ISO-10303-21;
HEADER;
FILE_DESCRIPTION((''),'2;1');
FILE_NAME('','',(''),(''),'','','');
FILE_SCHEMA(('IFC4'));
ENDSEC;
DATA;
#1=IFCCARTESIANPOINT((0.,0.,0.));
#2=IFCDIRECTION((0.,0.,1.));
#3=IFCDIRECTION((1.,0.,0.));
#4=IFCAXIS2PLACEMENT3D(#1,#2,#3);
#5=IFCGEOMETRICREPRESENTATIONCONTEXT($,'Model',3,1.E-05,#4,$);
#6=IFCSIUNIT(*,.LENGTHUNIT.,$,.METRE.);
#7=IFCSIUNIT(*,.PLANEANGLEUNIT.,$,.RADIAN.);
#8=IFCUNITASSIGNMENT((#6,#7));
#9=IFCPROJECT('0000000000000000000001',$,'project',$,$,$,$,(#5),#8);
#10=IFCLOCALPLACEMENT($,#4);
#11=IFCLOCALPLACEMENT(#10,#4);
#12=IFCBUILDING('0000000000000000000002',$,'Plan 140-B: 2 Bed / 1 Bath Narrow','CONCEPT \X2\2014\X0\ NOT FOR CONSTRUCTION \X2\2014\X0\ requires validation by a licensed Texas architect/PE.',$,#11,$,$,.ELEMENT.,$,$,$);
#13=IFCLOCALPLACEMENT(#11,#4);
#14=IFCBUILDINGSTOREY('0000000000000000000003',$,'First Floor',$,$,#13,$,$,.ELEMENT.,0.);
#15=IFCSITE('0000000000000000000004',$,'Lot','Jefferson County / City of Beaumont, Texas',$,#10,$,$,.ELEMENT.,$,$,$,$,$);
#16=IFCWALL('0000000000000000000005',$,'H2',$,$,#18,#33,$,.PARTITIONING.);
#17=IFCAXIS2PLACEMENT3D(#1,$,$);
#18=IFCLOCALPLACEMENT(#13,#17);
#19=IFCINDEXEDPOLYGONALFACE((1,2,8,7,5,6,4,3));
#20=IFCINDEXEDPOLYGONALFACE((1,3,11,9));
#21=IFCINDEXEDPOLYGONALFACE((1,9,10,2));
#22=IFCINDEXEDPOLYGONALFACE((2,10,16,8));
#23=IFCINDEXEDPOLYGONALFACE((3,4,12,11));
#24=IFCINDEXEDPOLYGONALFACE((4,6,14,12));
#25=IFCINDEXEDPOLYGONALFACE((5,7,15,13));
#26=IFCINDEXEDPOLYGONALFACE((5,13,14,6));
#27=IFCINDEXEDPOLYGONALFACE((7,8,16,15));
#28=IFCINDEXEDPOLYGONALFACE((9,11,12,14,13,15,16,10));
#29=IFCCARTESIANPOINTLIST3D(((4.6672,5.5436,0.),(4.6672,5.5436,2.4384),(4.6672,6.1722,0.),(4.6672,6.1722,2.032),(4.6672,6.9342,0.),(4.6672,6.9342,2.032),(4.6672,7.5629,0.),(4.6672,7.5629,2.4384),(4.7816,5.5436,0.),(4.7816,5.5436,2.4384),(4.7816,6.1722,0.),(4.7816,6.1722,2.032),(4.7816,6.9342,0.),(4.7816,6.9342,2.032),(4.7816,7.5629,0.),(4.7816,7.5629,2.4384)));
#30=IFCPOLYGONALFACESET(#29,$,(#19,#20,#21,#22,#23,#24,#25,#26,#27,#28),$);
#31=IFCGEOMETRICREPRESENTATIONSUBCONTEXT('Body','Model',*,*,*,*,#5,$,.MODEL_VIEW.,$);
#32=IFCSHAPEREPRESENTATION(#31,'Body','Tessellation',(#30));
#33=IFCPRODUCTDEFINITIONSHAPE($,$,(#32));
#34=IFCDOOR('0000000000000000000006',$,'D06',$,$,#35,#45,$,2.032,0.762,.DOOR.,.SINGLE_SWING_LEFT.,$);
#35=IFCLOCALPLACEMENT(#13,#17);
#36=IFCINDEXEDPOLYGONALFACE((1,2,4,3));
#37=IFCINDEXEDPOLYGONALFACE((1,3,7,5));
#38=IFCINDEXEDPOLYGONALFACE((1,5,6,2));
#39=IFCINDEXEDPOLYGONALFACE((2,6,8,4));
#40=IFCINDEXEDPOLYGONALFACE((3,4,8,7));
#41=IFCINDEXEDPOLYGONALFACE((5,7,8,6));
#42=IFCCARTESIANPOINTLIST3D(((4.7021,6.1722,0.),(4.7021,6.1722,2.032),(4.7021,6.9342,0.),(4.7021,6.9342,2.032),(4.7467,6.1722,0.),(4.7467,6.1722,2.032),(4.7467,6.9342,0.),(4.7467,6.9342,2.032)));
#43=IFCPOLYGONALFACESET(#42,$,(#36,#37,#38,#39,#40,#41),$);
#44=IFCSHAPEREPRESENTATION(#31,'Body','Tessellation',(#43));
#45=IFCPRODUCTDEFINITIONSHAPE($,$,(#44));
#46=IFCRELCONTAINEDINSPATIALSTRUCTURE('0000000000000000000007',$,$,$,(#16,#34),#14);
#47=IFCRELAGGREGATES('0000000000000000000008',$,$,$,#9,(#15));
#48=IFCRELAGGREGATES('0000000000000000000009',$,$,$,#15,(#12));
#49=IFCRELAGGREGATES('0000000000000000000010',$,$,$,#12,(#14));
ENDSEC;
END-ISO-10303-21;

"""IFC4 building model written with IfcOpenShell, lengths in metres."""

from ifc_helpers import new_model, si_unit, frame, frame_2d, origin_with_axes, place, context, subcontext, project, spatial, rectangle, extrude, element, fill, save


model = new_model("IFC4")

# Units and contexts
model_context = context("Model", 3, precision=1e-05, world=origin_with_axes())
body_context = subcontext(model_context, "Body", "Model", "MODEL_VIEW")
ifc_project = project(units=[si_unit("LENGTHUNIT", "METRE"), si_unit("PLANEANGLEUNIT", "RADIAN")], contexts=[model_context])

# Site, building, storey
site_placement = place(None, origin_with_axes())
site = spatial("IfcSite", under=ifc_project, at=site_placement, Name="Lot", Description="Jefferson County / City of Beaumont, Texas", CompositionType="ELEMENT")
building_placement = place(site_placement, origin_with_axes())
building = spatial("IfcBuilding", under=site, at=building_placement, Name="Plan 140-B: 2 Bed / 1 Bath Narrow", Description="CONCEPT — NOT FOR CONSTRUCTION — requires validation by a licensed Texas architect/PE.", CompositionType="ELEMENT")
storey_placement = place(building_placement, origin_with_axes())
storey = spatial("IfcBuildingStorey", under=building, at=storey_placement, Name="First Floor", CompositionType="ELEMENT", Elevation=0.0)

# Wall, opening, door
wall_1_placement = place(storey_placement, frame((4.7244, 5.5436, 0.0), z_axis=(0.0, 0.0, 1.0), x_axis=(0.0, 1.0, 0.0)))
wall_1 = element("IfcWall", 1, at=wall_1_placement, inside=storey, Name="H2", PredefinedType="PARTITIONING", context=body_context, shape_type="SweptSolid", body=[
    extrude(rectangle(XDim=2.0193, YDim=0.1143, at=frame_2d((1.0097, 0.0), x_axis=(1.0, 0.0))), origin_with_axes(), (0.0, 0.0, 1.0), 2.4384),
])
opening_1_placement = place(wall_1_placement, frame((0.6287, 0.0, 0.0), z_axis=(0.0, 0.0, 1.0), x_axis=(1.0, 0.0, 0.0)))
opening_1 = element("IfcOpeningElement", 2, at=opening_1_placement, cuts=wall_1, PredefinedType="OPENING", context=body_context, shape_type="SweptSolid", body=[
    extrude(rectangle(XDim=0.762, YDim=0.1448, at=frame_2d((0.381, 0.0), x_axis=(1.0, 0.0))), origin_with_axes(), (0.0, 0.0, 1.0), 2.032),
])
door_1_placement = place(opening_1_placement, origin_with_axes())
door_1 = element("IfcDoor", 3, at=door_1_placement, inside=storey, Name="D06", OperationType="SINGLE_SWING_LEFT", OverallHeight=2.032, OverallWidth=0.762, PredefinedType="DOOR", context=body_context, shape_type="SweptSolid", body=[
    extrude(rectangle(XDim=0.762, YDim=0.0445, at=frame_2d((0.381, 0.0), x_axis=(1.0, 0.0))), origin_with_axes(), (0.0, 0.0, 1.0), 2.032),
])
fill(opening_1, door_1)

save(model, "model.ifc")
